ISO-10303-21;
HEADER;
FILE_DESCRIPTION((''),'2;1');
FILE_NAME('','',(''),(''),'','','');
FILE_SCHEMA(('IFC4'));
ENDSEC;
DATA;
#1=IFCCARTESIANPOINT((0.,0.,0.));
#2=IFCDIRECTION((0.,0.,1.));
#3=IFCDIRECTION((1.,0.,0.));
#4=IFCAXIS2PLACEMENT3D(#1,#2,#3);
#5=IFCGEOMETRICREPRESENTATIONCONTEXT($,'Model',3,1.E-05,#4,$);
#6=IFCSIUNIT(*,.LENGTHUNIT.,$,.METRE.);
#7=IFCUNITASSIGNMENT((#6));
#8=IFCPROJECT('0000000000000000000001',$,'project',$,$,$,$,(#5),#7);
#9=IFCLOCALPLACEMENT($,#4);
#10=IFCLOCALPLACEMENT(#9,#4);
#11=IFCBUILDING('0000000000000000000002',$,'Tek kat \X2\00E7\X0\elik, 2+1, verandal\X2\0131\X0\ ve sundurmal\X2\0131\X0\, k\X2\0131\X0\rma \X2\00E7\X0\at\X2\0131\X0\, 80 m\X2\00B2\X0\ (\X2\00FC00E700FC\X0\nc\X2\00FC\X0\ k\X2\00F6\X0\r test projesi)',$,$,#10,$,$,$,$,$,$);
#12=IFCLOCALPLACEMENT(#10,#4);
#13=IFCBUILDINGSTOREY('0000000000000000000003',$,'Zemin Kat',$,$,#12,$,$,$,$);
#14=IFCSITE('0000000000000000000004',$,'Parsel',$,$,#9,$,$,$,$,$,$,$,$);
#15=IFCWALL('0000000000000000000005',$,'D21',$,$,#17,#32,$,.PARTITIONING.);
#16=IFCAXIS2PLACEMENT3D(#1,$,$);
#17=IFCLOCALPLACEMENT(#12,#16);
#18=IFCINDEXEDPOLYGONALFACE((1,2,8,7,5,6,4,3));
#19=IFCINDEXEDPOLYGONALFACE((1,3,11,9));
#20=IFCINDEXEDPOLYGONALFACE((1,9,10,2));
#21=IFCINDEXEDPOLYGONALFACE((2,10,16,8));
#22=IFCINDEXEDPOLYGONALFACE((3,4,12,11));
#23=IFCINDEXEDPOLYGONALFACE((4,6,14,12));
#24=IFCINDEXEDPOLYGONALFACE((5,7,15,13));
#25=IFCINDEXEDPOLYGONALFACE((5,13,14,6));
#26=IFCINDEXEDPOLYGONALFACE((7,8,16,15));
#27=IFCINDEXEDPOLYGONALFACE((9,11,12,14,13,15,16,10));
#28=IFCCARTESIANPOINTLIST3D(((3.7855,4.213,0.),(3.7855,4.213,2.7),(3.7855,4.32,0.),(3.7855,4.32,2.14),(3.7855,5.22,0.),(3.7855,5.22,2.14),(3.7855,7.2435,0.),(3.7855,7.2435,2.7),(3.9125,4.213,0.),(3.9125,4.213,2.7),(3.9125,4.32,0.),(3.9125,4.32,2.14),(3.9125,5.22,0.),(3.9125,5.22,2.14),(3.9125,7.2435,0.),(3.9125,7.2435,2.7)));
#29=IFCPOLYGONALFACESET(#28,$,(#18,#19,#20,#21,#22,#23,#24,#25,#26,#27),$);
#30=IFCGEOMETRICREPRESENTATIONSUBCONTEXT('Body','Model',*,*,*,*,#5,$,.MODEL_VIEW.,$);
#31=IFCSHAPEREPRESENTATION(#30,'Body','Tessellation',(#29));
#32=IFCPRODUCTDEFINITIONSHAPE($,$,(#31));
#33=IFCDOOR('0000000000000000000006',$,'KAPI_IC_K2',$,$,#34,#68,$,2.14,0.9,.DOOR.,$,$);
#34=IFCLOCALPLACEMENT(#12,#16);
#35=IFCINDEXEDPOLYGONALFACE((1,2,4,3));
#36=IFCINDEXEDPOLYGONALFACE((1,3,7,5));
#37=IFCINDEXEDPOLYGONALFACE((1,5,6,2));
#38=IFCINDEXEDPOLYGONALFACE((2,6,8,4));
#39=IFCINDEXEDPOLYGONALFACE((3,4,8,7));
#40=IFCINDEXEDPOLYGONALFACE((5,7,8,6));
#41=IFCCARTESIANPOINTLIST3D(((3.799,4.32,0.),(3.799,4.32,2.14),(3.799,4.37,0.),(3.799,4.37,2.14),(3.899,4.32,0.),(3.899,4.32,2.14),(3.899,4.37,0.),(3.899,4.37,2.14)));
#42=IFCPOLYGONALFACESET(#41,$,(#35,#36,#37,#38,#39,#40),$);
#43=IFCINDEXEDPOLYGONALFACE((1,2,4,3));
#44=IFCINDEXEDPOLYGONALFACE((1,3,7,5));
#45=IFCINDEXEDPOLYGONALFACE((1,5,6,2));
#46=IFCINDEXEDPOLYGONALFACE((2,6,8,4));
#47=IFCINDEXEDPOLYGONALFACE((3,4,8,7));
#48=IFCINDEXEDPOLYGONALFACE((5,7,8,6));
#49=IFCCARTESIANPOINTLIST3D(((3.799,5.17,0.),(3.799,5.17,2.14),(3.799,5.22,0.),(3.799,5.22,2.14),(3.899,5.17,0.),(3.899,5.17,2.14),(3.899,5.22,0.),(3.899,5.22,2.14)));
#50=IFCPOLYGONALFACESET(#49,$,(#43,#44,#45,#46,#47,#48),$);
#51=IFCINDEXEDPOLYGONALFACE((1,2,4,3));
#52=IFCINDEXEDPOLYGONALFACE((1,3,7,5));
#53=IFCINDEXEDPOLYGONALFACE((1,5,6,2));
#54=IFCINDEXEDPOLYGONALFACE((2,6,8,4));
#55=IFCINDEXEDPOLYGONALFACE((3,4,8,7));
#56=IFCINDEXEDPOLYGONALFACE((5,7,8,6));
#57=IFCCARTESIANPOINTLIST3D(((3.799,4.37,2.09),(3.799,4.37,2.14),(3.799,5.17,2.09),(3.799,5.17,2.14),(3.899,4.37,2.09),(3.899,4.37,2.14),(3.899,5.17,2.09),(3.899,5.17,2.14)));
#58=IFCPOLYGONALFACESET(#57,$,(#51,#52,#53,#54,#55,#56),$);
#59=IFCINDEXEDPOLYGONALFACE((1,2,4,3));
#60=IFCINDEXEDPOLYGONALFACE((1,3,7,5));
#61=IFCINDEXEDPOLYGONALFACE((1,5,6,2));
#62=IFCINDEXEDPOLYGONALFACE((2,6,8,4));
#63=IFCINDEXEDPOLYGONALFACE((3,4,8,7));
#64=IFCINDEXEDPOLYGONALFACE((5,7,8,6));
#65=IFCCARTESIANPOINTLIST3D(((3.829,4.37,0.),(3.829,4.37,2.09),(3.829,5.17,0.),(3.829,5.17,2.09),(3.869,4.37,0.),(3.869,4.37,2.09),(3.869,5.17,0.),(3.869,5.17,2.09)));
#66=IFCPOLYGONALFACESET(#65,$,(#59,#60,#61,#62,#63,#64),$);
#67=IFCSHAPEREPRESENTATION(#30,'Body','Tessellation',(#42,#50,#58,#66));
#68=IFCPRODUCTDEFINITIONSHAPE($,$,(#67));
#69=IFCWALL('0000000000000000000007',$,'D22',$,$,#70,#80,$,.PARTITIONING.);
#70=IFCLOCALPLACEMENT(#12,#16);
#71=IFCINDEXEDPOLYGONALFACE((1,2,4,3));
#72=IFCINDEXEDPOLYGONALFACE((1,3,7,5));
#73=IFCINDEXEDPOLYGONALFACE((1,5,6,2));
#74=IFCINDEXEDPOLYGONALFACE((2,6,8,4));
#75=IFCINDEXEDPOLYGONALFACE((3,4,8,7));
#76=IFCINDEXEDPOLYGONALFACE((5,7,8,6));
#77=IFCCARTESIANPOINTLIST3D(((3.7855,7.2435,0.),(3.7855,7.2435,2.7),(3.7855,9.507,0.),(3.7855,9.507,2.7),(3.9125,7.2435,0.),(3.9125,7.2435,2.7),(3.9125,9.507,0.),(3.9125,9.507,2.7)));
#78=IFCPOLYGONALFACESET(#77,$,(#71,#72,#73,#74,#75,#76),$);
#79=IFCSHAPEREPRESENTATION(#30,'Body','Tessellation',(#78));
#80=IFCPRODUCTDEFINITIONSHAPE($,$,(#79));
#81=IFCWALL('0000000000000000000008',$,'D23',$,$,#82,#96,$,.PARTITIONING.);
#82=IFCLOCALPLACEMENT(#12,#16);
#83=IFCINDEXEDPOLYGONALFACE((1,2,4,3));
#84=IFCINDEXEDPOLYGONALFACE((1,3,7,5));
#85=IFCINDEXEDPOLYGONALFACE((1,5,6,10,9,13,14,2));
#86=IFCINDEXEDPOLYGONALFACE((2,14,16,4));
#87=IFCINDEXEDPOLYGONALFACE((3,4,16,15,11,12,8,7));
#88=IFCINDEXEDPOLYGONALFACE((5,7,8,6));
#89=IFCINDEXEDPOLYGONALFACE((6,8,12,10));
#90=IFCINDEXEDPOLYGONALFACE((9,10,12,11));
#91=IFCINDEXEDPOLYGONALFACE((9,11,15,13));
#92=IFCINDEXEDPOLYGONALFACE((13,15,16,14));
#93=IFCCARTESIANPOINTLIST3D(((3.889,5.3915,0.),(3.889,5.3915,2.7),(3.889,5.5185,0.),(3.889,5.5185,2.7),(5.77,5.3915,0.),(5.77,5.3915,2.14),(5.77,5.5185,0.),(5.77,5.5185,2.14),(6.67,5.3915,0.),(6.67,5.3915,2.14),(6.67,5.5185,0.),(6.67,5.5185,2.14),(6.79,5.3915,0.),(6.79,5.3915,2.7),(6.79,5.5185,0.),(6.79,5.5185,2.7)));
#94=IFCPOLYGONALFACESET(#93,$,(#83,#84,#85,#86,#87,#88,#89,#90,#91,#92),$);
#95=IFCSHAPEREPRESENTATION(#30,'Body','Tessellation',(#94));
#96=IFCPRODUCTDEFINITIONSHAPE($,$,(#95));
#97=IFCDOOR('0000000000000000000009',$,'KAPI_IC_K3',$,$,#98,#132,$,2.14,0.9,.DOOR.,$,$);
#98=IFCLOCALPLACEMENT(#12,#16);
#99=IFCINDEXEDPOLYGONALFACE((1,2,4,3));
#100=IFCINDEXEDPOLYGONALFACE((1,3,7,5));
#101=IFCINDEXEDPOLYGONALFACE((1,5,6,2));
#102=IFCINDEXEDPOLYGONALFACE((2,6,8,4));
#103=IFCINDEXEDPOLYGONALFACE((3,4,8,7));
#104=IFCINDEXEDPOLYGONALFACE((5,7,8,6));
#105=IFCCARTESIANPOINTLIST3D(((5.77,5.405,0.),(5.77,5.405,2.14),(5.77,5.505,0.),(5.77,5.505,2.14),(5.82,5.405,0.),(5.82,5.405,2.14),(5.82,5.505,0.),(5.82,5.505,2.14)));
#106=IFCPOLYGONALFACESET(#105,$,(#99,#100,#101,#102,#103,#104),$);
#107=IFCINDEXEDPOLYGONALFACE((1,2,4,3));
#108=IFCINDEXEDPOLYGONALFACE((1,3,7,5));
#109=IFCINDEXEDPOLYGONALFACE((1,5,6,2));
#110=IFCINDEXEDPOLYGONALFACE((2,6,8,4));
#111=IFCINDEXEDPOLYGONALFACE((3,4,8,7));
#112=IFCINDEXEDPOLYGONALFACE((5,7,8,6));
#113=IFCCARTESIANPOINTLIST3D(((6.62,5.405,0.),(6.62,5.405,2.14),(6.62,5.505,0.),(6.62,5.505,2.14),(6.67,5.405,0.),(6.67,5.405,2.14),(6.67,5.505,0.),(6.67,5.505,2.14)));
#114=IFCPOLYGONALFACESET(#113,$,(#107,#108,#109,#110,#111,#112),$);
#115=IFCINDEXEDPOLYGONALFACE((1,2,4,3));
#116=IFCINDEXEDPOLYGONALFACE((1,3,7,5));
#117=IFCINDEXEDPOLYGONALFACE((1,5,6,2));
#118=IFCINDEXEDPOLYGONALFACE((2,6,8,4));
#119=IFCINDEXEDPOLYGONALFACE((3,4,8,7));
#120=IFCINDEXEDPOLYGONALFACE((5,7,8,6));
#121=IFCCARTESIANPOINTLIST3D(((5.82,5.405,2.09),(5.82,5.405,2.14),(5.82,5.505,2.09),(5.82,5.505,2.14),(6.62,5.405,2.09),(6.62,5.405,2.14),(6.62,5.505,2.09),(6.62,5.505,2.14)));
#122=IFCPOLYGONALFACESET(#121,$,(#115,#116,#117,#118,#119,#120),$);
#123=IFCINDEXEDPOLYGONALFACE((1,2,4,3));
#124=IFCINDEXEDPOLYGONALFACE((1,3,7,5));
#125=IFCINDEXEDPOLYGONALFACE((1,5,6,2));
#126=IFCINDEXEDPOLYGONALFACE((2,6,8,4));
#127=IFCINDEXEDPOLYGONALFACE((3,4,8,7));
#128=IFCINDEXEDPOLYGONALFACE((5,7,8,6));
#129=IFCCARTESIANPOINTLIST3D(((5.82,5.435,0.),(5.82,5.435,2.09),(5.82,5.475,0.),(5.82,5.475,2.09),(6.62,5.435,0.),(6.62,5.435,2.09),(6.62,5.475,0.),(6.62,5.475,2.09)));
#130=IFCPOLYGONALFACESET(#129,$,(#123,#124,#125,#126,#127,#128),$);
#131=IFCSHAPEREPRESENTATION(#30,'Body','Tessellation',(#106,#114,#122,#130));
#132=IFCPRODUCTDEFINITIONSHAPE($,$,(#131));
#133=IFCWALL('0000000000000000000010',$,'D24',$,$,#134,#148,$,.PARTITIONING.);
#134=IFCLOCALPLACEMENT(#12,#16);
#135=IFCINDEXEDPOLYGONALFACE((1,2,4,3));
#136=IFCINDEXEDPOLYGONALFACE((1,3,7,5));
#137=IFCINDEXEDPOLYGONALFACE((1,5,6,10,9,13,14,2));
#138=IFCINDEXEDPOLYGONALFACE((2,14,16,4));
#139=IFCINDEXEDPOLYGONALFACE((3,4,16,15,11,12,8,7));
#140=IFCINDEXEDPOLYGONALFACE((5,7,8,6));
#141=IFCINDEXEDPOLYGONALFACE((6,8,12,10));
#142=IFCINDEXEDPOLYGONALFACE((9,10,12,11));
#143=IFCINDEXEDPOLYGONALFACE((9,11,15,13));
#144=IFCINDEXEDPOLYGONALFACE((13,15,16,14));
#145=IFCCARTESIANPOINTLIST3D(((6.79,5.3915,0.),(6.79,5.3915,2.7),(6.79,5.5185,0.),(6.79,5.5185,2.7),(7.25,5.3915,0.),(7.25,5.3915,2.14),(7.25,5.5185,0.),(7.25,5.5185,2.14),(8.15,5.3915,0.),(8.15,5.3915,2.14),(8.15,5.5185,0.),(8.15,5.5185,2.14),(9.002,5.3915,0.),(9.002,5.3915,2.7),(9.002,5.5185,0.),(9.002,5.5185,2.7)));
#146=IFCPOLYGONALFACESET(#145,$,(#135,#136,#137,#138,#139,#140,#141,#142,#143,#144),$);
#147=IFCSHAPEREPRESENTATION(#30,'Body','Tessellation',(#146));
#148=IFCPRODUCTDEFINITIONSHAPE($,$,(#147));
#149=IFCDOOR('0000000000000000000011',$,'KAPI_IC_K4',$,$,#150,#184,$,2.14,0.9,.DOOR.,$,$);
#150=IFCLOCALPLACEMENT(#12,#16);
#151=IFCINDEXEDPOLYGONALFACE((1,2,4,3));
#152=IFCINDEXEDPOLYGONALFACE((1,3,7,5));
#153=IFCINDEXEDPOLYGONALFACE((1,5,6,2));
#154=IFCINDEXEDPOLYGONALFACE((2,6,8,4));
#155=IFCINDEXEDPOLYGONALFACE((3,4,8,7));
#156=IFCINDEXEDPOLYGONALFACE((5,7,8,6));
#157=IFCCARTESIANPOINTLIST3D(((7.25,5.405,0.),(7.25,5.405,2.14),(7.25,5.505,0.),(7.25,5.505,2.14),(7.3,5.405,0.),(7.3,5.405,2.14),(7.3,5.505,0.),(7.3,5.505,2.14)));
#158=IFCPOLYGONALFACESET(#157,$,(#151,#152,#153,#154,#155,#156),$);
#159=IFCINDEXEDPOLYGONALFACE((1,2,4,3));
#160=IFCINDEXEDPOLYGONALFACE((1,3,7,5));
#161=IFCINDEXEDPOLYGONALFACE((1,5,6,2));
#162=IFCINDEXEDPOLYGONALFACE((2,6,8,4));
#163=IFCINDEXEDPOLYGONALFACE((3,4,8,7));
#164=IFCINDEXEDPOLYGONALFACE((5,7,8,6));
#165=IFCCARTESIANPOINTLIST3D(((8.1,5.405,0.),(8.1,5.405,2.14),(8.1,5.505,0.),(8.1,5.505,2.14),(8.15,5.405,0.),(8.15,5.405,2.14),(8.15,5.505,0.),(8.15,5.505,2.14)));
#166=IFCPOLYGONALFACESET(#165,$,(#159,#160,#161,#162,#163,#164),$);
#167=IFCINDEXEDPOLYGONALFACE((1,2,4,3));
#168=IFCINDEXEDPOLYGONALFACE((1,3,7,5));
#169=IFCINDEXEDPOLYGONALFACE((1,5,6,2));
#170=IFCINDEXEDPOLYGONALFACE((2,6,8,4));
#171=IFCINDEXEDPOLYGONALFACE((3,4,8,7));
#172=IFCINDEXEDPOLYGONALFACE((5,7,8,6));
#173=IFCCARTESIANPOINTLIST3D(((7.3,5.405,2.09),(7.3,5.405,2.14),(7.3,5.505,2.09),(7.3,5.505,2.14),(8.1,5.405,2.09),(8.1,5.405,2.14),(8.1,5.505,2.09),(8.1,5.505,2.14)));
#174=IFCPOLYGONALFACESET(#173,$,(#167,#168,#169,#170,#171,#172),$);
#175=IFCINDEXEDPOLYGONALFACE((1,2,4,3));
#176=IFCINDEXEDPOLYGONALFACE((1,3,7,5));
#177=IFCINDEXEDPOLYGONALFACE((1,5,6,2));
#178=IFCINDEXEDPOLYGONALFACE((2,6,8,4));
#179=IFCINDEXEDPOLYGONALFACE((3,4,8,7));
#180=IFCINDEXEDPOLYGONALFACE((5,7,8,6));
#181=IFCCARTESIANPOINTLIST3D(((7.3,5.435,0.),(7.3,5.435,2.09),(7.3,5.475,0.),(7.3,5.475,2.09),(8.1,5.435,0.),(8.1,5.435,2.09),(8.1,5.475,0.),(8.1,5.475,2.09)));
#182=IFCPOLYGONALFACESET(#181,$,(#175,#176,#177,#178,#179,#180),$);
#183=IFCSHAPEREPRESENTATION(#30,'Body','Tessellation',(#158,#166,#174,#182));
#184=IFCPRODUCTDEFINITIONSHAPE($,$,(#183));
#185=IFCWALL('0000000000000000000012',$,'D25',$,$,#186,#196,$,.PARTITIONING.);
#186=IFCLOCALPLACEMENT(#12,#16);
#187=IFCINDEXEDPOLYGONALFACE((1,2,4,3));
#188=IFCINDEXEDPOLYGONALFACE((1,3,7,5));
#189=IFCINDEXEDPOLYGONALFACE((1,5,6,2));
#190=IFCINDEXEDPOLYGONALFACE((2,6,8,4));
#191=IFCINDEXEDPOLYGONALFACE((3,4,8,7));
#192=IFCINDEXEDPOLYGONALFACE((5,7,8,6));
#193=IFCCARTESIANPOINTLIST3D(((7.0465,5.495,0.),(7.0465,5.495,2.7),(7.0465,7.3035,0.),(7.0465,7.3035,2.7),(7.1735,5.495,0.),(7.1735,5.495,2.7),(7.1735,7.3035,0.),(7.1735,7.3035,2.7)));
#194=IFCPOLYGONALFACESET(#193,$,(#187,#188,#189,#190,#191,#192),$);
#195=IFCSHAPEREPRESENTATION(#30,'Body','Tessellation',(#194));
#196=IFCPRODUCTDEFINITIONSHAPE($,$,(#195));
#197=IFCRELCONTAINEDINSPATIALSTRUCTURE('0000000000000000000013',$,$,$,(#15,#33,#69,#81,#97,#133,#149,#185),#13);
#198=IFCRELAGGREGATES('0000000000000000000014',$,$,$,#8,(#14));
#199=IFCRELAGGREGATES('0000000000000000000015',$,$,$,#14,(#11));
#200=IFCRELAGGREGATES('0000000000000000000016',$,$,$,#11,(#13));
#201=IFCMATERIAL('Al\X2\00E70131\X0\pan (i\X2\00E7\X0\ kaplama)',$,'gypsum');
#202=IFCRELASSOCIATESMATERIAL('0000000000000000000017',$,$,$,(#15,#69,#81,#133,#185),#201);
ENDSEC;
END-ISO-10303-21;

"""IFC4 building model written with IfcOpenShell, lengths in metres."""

from ifc_helpers import new_model, si_unit, frame, origin_with_axes, place, context, subcontext, project, spatial, line, indexed_curve, outline, extrude, material, element, fill, save


model = new_model("IFC4")

# Units and contexts
model_context = context("Model", 3, precision=1e-05, world=origin_with_axes())
body_context = subcontext(model_context, "Body", "Model", "MODEL_VIEW")
ifc_project = project(units=[si_unit("LENGTHUNIT", "METRE")], contexts=[model_context])

# Site, building, storey
site_placement = place(None, origin_with_axes())
site = spatial("IfcSite", under=ifc_project, at=site_placement, Name="Parsel")
building_placement = place(site_placement, origin_with_axes())
building = spatial("IfcBuilding", under=site, at=building_placement, Name="Tek kat çelik, 2+1, verandalı ve sundurmalı, kırma çatı, 80 m² (üçüncü kör test projesi)")
storey_placement = place(building_placement, origin_with_axes())
storey = spatial("IfcBuildingStorey", under=building, at=storey_placement, Name="Zemin Kat")

# Shared definitions
ifc_material_1 = material(Name="Alçıpan (iç kaplama)", Category="gypsum")

# Wall, opening, door
wall_1_placement = place(storey_placement, origin_with_axes())
wall_1 = element("IfcWall", 1, at=wall_1_placement, inside=storey, material=ifc_material_1, Name="D21", PredefinedType="PARTITIONING", context=body_context, shape_type="SweptSolid", body=[
    extrude(outline(indexed_curve([(0.0, 0.0), (0.127, 0.0), (0.127, 3.0305), (0.0, 3.0305)], segments=[line(1, 2, 3, 4, 1)])), frame((3.7855, 4.213, 0.0), z_axis=(0.0, 0.0, 1.0), x_axis=(1.0, 0.0, 0.0)), (0.0, 0.0, 1.0), 2.7),
])
opening_1_placement = place(wall_1_placement, origin_with_axes())
opening_1 = element("IfcOpeningElement", 2, at=opening_1_placement, cuts=wall_1, PredefinedType="OPENING", context=body_context, shape_type="SweptSolid", body=[
    extrude(outline(indexed_curve([(0.0, 0.0), (0.167, 0.0), (0.167, 0.9), (0.0, 0.9)], segments=[line(1, 2, 3, 4, 1)])), frame((3.7655, 4.32, 0.0), z_axis=(0.0, 0.0, 1.0), x_axis=(1.0, 0.0, 0.0)), (0.0, 0.0, 1.0), 2.14),
])
door_1_placement = place(storey_placement, origin_with_axes())
door_1 = element("IfcDoor", 3, at=door_1_placement, inside=storey, Name="KAPI_IC_K2", OverallHeight=2.14, OverallWidth=0.9, PredefinedType="DOOR", context=body_context, shape_type="SweptSolid", body=[
    extrude(outline(indexed_curve([(0.0, 0.0), (0.1, 0.0), (0.1, 0.05), (0.0, 0.05)], segments=[line(1, 2, 3, 4, 1)])), frame((3.799, 4.32, 0.0), z_axis=(0.0, 0.0, 1.0), x_axis=(1.0, 0.0, 0.0)), (0.0, 0.0, 1.0), 2.14),
    extrude(outline(indexed_curve([(0.0, 0.0), (0.1, 0.0), (0.1, 0.05), (0.0, 0.05)], segments=[line(1, 2, 3, 4, 1)])), frame((3.799, 5.17, 0.0), z_axis=(0.0, 0.0, 1.0), x_axis=(1.0, 0.0, 0.0)), (0.0, 0.0, 1.0), 2.14),
    extrude(outline(indexed_curve([(0.0, 0.0), (0.1, 0.0), (0.1, 0.8), (0.0, 0.8)], segments=[line(1, 2, 3, 4, 1)])), frame((3.799, 4.37, 2.09), z_axis=(0.0, 0.0, 1.0), x_axis=(1.0, 0.0, 0.0)), (0.0, 0.0, 1.0), 0.05),
    extrude(outline(indexed_curve([(0.0, 0.0), (0.04, 0.0), (0.04, 0.8), (0.0, 0.8)], segments=[line(1, 2, 3, 4, 1)])), frame((3.829, 4.37, 0.0), z_axis=(0.0, 0.0, 1.0), x_axis=(1.0, 0.0, 0.0)), (0.0, 0.0, 1.0), 2.09),
])
fill(opening_1, door_1)

# Wall
wall_2_placement = place(storey_placement, origin_with_axes())
element("IfcWall", 4, at=wall_2_placement, inside=storey, material=ifc_material_1, Name="D22", PredefinedType="PARTITIONING", context=body_context, shape_type="SweptSolid", body=[
    extrude(outline(indexed_curve([(0.0, 0.0), (0.127, 0.0), (0.127, 2.2635), (0.0, 2.2635)], segments=[line(1, 2, 3, 4, 1)])), frame((3.7855, 7.2435, 0.0), z_axis=(0.0, 0.0, 1.0), x_axis=(1.0, 0.0, 0.0)), (0.0, 0.0, 1.0), 2.7),
])

# Walls, openings, doors
wall_3_placement = place(storey_placement, origin_with_axes())
wall_3 = element("IfcWall", 5, at=wall_3_placement, inside=storey, material=ifc_material_1, Name="D23", PredefinedType="PARTITIONING", context=body_context, shape_type="SweptSolid", body=[
    extrude(outline(indexed_curve([(0.0, 0.0), (2.901, 0.0), (2.901, 0.127), (0.0, 0.127)], segments=[line(1, 2, 3, 4, 1)])), frame((3.889, 5.3915, 0.0), z_axis=(0.0, 0.0, 1.0), x_axis=(1.0, 0.0, 0.0)), (0.0, 0.0, 1.0), 2.7),
])
opening_2_placement = place(wall_3_placement, origin_with_axes())
opening_2 = element("IfcOpeningElement", 6, at=opening_2_placement, cuts=wall_3, PredefinedType="OPENING", context=body_context, shape_type="SweptSolid", body=[
    extrude(outline(indexed_curve([(0.0, 0.0), (0.9, 0.0), (0.9, 0.167), (0.0, 0.167)], segments=[line(1, 2, 3, 4, 1)])), frame((5.77, 5.3715, 0.0), z_axis=(0.0, 0.0, 1.0), x_axis=(1.0, 0.0, 0.0)), (0.0, 0.0, 1.0), 2.14),
])
door_2_placement = place(storey_placement, origin_with_axes())
door_2 = element("IfcDoor", 7, at=door_2_placement, inside=storey, Name="KAPI_IC_K3", OverallHeight=2.14, OverallWidth=0.9, PredefinedType="DOOR", context=body_context, shape_type="SweptSolid", body=[
    extrude(outline(indexed_curve([(0.0, 0.0), (0.05, 0.0), (0.05, 0.1), (0.0, 0.1)], segments=[line(1, 2, 3, 4, 1)])), frame((5.77, 5.405, 0.0), z_axis=(0.0, 0.0, 1.0), x_axis=(1.0, 0.0, 0.0)), (0.0, 0.0, 1.0), 2.14),
    extrude(outline(indexed_curve([(0.0, 0.0), (0.05, 0.0), (0.05, 0.1), (0.0, 0.1)], segments=[line(1, 2, 3, 4, 1)])), frame((6.62, 5.405, 0.0), z_axis=(0.0, 0.0, 1.0), x_axis=(1.0, 0.0, 0.0)), (0.0, 0.0, 1.0), 2.14),
    extrude(outline(indexed_curve([(0.0, 0.0), (0.8, 0.0), (0.8, 0.1), (0.0, 0.1)], segments=[line(1, 2, 3, 4, 1)])), frame((5.82, 5.405, 2.09), z_axis=(0.0, 0.0, 1.0), x_axis=(1.0, 0.0, 0.0)), (0.0, 0.0, 1.0), 0.05),
    extrude(outline(indexed_curve([(0.0, 0.0), (0.8, 0.0), (0.8, 0.04), (0.0, 0.04)], segments=[line(1, 2, 3, 4, 1)])), frame((5.82, 5.435, 0.0), z_axis=(0.0, 0.0, 1.0), x_axis=(1.0, 0.0, 0.0)), (0.0, 0.0, 1.0), 2.09),
])
fill(opening_2, door_2)
wall_4_placement = place(storey_placement, origin_with_axes())
wall_4 = element("IfcWall", 8, at=wall_4_placement, inside=storey, material=ifc_material_1, Name="D24", PredefinedType="PARTITIONING", context=body_context, shape_type="SweptSolid", body=[
    extrude(outline(indexed_curve([(0.0, 0.0), (2.212, 0.0), (2.212, 0.127), (0.0, 0.127)], segments=[line(1, 2, 3, 4, 1)])), frame((6.79, 5.3915, 0.0), z_axis=(0.0, 0.0, 1.0), x_axis=(1.0, 0.0, 0.0)), (0.0, 0.0, 1.0), 2.7),
])
opening_3_placement = place(wall_4_placement, origin_with_axes())
opening_3 = element("IfcOpeningElement", 9, at=opening_3_placement, cuts=wall_4, PredefinedType="OPENING", context=body_context, shape_type="SweptSolid", body=[
    extrude(outline(indexed_curve([(0.0, 0.0), (0.9, 0.0), (0.9, 0.167), (0.0, 0.167)], segments=[line(1, 2, 3, 4, 1)])), frame((7.25, 5.3715, 0.0), z_axis=(0.0, 0.0, 1.0), x_axis=(1.0, 0.0, 0.0)), (0.0, 0.0, 1.0), 2.14),
])
door_3_placement = place(storey_placement, origin_with_axes())
door_3 = element("IfcDoor", 10, at=door_3_placement, inside=storey, Name="KAPI_IC_K4", OverallHeight=2.14, OverallWidth=0.9, PredefinedType="DOOR", context=body_context, shape_type="SweptSolid", body=[
    extrude(outline(indexed_curve([(0.0, 0.0), (0.05, 0.0), (0.05, 0.1), (0.0, 0.1)], segments=[line(1, 2, 3, 4, 1)])), frame((7.25, 5.405, 0.0), z_axis=(0.0, 0.0, 1.0), x_axis=(1.0, 0.0, 0.0)), (0.0, 0.0, 1.0), 2.14),
    extrude(outline(indexed_curve([(0.0, 0.0), (0.05, 0.0), (0.05, 0.1), (0.0, 0.1)], segments=[line(1, 2, 3, 4, 1)])), frame((8.1, 5.405, 0.0), z_axis=(0.0, 0.0, 1.0), x_axis=(1.0, 0.0, 0.0)), (0.0, 0.0, 1.0), 2.14),
    extrude(outline(indexed_curve([(0.0, 0.0), (0.8, 0.0), (0.8, 0.1), (0.0, 0.1)], segments=[line(1, 2, 3, 4, 1)])), frame((7.3, 5.405, 2.09), z_axis=(0.0, 0.0, 1.0), x_axis=(1.0, 0.0, 0.0)), (0.0, 0.0, 1.0), 0.05),
    extrude(outline(indexed_curve([(0.0, 0.0), (0.8, 0.0), (0.8, 0.04), (0.0, 0.04)], segments=[line(1, 2, 3, 4, 1)])), frame((7.3, 5.435, 0.0), z_axis=(0.0, 0.0, 1.0), x_axis=(1.0, 0.0, 0.0)), (0.0, 0.0, 1.0), 2.09),
])
fill(opening_3, door_3)

# Wall
wall_5_placement = place(storey_placement, origin_with_axes())
element("IfcWall", 11, at=wall_5_placement, inside=storey, material=ifc_material_1, Name="D25", PredefinedType="PARTITIONING", context=body_context, shape_type="SweptSolid", body=[
    extrude(outline(indexed_curve([(0.0, 0.0), (0.127, 0.0), (0.127, 1.8085), (0.0, 1.8085)], segments=[line(1, 2, 3, 4, 1)])), frame((7.0465, 5.495, 0.0), z_axis=(0.0, 0.0, 1.0), x_axis=(1.0, 0.0, 0.0)), (0.0, 0.0, 1.0), 2.7),
])

save(model, "model.ifc")
